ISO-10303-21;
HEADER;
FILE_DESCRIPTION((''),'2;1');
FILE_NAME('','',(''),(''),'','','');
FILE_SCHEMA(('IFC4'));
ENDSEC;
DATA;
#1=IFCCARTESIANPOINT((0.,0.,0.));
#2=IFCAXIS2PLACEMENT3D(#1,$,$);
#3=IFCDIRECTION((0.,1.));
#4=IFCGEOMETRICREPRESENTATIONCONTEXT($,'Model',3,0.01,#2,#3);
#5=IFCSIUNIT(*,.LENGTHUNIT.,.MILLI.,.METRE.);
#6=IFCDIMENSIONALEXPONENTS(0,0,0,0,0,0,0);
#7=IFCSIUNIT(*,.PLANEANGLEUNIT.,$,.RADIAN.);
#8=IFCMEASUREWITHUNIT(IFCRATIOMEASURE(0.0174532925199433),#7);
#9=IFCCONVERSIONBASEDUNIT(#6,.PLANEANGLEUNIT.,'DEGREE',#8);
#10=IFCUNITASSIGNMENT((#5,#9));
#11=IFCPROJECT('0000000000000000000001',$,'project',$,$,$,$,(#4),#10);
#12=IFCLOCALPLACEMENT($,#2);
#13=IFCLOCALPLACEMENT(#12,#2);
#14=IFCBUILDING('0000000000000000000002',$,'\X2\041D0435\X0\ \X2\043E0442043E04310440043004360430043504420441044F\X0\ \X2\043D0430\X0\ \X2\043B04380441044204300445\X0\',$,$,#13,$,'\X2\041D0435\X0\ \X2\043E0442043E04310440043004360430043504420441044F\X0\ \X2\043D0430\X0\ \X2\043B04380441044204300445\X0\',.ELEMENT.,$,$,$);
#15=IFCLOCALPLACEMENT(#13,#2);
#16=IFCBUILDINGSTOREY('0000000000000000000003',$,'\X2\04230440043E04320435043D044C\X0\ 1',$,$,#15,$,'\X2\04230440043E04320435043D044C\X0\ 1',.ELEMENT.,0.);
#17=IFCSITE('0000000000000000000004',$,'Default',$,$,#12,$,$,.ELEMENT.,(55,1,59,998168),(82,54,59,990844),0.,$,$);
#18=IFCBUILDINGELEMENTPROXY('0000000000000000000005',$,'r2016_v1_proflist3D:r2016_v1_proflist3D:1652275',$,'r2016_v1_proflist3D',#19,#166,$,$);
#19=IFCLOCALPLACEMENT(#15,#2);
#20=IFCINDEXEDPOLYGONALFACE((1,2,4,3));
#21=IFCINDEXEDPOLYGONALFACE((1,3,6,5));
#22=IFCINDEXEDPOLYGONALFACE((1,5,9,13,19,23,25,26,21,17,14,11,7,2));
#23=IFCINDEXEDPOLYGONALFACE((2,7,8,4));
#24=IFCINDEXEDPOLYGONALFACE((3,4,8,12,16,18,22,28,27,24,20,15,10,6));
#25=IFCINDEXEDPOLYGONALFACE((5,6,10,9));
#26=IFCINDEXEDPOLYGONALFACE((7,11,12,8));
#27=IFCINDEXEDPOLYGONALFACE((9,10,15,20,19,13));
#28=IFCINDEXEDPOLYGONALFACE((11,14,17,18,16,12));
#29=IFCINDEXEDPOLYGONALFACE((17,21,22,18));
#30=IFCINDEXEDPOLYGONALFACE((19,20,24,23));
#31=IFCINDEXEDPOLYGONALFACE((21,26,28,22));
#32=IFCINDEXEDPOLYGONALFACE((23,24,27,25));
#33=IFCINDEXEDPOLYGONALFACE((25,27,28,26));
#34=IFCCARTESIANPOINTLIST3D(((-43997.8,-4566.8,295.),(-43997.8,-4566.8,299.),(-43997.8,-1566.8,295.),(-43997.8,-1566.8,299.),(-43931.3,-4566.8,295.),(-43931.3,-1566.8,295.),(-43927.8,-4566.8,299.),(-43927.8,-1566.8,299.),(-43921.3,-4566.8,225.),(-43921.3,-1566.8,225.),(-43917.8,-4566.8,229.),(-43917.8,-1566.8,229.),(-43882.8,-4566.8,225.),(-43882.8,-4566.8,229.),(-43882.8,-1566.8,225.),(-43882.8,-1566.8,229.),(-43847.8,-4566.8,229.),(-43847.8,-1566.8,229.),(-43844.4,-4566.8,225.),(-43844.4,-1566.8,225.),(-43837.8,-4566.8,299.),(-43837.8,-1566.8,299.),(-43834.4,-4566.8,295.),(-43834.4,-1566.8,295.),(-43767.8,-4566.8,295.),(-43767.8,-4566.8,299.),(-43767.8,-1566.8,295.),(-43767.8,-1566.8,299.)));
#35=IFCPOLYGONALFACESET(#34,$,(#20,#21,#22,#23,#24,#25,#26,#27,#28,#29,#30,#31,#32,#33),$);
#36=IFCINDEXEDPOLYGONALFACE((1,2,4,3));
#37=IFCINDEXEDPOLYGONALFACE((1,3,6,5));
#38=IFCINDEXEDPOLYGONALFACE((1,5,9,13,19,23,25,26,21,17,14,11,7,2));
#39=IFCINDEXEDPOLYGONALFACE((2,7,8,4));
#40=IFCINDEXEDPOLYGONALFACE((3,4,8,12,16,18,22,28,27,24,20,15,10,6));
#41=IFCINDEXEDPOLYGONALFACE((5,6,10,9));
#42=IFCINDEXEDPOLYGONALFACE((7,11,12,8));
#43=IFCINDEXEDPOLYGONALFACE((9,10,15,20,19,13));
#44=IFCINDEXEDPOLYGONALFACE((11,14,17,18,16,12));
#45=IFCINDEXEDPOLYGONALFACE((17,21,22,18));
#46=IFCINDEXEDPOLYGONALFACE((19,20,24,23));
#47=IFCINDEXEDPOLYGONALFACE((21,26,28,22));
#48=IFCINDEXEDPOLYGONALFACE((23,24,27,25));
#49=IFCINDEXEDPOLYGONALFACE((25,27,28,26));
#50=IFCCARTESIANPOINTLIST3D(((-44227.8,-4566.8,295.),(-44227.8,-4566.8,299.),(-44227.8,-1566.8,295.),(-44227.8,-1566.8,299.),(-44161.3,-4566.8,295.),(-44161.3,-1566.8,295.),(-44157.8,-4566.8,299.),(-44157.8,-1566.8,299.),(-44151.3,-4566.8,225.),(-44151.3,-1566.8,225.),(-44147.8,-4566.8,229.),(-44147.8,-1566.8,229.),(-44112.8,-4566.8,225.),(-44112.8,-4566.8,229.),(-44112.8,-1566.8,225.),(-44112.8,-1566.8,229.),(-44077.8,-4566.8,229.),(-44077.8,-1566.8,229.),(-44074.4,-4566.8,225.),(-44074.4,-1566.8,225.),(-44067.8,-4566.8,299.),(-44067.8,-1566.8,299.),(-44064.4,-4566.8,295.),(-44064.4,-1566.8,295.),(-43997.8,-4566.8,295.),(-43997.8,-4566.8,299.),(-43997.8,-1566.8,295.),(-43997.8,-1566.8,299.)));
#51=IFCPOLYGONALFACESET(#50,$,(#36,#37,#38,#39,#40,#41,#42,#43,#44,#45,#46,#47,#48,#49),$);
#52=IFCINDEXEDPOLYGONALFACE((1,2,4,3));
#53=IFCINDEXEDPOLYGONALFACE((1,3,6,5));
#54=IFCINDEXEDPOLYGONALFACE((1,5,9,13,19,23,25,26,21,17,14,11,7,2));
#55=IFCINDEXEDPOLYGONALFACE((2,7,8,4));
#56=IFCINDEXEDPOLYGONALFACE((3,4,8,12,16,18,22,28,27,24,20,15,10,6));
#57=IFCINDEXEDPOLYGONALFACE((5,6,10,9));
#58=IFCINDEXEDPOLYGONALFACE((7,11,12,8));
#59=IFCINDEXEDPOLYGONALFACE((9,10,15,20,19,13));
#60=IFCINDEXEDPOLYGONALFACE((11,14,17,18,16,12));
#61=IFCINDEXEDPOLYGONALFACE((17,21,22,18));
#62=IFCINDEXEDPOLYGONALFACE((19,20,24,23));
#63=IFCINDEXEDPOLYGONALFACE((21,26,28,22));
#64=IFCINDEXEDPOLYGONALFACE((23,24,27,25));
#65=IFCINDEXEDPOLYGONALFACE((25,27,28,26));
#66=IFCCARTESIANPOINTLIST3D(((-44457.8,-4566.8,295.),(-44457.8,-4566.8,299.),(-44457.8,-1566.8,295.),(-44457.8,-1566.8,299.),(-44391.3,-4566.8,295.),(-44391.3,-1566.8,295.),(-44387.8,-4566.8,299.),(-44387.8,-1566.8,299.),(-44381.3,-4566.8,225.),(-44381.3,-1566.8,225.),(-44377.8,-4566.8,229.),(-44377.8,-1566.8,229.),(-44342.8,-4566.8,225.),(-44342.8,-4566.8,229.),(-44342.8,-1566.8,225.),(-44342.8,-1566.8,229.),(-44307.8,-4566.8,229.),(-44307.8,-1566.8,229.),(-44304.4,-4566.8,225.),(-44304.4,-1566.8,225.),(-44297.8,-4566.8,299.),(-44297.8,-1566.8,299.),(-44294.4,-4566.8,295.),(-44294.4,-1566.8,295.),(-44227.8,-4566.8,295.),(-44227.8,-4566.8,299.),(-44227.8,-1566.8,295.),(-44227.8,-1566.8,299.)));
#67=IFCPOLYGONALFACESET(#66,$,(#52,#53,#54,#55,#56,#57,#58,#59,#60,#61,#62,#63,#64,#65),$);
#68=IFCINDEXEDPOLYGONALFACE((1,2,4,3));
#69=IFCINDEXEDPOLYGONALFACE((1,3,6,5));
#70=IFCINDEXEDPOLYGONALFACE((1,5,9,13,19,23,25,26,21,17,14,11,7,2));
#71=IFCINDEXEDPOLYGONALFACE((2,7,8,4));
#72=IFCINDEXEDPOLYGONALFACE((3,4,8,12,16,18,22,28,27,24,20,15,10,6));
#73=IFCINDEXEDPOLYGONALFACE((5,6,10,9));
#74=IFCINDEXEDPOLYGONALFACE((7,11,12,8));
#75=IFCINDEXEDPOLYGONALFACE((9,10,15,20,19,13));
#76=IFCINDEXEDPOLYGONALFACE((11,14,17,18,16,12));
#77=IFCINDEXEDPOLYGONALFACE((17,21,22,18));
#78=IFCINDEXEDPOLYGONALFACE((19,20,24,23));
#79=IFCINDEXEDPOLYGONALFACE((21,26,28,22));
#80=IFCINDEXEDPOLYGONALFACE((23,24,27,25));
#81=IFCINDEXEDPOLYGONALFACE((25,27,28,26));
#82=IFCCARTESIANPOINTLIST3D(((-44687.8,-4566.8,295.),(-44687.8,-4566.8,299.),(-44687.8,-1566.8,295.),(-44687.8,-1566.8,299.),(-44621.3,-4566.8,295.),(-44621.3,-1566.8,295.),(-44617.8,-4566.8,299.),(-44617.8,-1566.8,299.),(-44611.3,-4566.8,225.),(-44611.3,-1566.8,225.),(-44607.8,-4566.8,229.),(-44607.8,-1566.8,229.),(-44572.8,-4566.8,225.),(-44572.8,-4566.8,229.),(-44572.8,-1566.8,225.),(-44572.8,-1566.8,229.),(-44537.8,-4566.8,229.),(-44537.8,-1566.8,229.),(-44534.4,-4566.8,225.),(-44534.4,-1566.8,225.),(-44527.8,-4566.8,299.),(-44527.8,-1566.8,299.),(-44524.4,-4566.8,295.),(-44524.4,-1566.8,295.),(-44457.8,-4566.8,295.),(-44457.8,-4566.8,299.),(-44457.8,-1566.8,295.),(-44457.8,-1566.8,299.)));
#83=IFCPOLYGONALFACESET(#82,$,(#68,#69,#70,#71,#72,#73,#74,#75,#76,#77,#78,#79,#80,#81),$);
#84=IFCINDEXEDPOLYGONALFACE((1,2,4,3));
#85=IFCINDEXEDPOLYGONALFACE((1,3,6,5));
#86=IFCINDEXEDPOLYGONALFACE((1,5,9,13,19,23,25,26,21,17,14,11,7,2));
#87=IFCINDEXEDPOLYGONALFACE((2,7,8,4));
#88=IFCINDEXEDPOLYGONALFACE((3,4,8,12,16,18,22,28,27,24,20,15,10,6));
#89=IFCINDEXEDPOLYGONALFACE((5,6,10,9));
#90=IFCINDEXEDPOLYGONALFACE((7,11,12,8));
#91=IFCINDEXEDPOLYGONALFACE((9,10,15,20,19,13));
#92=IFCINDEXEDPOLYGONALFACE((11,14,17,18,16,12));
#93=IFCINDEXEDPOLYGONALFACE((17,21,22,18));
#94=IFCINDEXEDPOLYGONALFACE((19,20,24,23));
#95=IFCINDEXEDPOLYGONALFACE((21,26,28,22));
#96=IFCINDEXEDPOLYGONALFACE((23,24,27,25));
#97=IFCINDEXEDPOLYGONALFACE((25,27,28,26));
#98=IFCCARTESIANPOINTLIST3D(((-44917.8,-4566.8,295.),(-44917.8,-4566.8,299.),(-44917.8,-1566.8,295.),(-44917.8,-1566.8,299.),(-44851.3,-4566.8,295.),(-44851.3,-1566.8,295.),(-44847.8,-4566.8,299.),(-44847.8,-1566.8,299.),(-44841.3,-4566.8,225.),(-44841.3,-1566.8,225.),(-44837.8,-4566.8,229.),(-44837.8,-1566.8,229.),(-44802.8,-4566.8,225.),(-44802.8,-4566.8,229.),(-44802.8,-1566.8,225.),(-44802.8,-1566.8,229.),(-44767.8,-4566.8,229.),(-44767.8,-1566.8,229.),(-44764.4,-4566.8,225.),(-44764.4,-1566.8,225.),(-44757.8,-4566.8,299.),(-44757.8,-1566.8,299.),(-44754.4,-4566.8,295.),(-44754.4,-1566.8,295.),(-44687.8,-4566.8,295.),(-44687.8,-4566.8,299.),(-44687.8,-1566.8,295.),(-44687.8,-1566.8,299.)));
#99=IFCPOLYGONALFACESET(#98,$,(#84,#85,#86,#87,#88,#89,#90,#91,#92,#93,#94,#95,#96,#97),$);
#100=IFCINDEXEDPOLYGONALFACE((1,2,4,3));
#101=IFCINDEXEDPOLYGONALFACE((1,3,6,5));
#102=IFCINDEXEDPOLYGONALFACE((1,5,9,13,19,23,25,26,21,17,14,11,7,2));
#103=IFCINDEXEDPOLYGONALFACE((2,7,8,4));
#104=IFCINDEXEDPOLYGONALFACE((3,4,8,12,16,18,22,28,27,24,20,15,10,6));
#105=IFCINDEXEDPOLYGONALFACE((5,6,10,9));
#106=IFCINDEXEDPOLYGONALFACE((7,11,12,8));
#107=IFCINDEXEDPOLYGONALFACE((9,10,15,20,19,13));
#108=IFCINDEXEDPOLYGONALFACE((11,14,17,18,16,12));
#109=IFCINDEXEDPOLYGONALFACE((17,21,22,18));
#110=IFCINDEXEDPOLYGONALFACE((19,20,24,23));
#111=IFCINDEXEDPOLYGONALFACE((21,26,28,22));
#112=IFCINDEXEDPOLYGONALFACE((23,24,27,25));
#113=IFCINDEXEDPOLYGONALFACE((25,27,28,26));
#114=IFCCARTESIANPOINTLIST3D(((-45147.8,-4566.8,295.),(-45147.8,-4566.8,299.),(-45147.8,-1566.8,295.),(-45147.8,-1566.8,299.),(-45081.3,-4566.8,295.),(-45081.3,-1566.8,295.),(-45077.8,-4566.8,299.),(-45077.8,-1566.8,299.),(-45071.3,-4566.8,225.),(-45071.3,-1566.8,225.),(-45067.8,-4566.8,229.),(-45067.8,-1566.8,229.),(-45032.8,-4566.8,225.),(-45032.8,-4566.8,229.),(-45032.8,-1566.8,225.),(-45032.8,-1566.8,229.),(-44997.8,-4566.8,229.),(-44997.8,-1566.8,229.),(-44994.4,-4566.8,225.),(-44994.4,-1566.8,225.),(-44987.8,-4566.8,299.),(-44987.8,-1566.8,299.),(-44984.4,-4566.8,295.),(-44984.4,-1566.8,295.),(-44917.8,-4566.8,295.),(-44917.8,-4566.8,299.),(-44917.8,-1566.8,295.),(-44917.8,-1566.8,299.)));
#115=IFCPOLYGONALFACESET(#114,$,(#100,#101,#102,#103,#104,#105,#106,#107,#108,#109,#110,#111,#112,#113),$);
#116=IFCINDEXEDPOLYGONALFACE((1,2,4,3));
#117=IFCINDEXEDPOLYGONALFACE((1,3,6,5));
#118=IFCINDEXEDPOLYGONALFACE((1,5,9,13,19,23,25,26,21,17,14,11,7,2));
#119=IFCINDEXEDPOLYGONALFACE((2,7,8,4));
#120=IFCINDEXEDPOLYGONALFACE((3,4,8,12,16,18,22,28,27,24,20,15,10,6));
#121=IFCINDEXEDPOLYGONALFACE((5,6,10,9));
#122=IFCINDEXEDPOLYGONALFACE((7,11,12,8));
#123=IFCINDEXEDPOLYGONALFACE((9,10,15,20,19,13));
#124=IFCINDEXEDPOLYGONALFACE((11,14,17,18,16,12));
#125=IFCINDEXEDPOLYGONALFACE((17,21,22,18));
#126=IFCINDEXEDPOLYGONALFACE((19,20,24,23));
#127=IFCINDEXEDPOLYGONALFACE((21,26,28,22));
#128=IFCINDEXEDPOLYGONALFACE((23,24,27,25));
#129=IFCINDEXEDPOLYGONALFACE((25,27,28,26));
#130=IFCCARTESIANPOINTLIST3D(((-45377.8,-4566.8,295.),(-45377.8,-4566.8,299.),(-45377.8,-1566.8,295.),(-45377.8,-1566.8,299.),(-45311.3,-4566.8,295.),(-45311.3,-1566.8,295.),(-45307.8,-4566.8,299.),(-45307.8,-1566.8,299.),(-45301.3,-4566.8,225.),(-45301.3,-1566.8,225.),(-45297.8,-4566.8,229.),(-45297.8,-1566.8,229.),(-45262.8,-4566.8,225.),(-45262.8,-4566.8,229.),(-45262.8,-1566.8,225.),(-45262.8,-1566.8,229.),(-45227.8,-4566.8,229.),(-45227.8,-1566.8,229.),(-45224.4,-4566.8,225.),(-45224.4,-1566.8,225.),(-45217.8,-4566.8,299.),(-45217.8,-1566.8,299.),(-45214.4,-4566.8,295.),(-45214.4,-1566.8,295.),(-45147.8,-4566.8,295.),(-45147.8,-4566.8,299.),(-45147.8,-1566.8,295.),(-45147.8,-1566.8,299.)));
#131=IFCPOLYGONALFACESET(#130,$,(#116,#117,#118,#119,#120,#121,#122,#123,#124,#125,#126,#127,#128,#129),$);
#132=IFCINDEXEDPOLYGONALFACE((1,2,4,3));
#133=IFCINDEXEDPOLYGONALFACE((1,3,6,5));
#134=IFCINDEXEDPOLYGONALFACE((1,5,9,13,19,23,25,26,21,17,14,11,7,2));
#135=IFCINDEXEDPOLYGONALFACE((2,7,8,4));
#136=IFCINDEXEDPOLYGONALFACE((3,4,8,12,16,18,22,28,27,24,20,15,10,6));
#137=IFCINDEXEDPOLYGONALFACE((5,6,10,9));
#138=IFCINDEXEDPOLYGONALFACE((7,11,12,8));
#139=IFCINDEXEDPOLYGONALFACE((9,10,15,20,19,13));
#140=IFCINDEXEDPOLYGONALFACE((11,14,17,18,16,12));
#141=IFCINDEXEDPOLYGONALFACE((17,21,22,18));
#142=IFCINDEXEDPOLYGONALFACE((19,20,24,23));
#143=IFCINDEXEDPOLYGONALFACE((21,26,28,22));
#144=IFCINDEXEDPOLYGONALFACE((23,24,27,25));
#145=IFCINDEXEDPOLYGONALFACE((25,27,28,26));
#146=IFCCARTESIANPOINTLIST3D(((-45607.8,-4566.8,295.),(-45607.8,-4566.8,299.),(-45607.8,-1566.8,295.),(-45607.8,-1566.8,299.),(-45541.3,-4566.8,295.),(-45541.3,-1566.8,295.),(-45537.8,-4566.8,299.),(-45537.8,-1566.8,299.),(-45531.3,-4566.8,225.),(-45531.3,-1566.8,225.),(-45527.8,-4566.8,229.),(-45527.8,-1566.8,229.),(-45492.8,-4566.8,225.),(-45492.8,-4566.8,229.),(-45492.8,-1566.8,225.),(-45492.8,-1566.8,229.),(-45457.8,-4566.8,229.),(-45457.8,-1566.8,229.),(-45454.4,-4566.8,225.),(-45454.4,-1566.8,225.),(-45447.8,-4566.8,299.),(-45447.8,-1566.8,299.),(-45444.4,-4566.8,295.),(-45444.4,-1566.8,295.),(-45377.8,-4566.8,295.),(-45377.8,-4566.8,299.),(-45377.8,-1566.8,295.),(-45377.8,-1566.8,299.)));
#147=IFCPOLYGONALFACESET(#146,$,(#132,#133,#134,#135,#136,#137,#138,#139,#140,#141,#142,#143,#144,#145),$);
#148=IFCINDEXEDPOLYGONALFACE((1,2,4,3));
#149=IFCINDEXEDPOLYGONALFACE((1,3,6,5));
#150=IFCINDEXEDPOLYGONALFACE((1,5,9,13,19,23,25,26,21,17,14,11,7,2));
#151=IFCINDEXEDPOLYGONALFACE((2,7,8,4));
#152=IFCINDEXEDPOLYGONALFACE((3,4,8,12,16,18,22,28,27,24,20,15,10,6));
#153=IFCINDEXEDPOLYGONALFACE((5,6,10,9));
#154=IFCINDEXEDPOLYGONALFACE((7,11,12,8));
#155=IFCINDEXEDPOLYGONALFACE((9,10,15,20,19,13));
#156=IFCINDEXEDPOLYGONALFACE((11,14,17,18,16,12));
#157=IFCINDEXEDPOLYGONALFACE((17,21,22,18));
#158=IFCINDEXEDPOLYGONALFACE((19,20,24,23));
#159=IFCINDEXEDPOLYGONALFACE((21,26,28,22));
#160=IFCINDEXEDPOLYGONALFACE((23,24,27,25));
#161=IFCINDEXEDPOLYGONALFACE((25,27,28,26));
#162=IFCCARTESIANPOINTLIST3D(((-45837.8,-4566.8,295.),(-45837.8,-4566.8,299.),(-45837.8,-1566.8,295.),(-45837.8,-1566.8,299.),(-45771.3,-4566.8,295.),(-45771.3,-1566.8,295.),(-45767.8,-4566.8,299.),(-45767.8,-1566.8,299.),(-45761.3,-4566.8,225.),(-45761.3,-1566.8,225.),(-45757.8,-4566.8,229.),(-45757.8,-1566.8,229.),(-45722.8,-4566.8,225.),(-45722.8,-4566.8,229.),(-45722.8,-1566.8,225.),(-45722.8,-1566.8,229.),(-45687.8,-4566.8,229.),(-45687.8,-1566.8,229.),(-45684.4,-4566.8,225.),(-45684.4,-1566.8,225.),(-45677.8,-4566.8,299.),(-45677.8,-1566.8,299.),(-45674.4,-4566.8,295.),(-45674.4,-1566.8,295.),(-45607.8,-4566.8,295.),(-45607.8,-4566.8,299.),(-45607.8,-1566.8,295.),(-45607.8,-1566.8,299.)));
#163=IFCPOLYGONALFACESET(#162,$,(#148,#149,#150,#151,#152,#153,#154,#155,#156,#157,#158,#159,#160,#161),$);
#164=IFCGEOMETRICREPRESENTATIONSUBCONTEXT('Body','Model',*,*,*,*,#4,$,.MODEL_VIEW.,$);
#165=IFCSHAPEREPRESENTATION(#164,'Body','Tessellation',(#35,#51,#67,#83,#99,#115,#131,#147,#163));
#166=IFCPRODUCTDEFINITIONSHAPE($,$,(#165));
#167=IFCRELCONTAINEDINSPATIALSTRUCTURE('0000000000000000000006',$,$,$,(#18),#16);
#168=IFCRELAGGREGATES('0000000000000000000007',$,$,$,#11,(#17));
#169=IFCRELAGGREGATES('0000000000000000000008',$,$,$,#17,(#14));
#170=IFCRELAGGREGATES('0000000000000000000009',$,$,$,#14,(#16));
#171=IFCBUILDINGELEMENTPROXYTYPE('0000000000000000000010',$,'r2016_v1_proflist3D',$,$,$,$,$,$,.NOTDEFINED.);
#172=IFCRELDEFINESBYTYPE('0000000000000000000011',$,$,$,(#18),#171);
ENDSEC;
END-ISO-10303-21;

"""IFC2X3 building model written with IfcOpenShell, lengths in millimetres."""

from ifc_helpers import new_model, entity, si_unit, converted_unit, direction, frame, origin, place, context, subcontext, project, spatial, polyline, outline, extrude, source, transform, mapped, type_object, type_shapes, element, save


model = new_model("IFC2X3")

# Units and contexts
model_context = context("Model", 3, precision=0.01, world=origin(), true_north=direction((0.0, 1.0)))
body_context = subcontext(model_context, "Body", "Model", "MODEL_VIEW")
ifc_project = project(units=[si_unit("LENGTHUNIT", "METRE", prefix="MILLI"), converted_unit("PLANEANGLEUNIT", "DEGREE", entity("IfcRatioMeasure", 0.0174532925199433), si_unit("PLANEANGLEUNIT", "RADIAN"), dimensions=[0, 0, 0, 0, 0, 0, 0])], contexts=[model_context])

# Site, building, storey
site_placement = place(None, origin())
site = spatial("IfcSite", under=ifc_project, at=site_placement, Name="Default", CompositionType="ELEMENT", RefLatitude=(55, 1, 59, 998168), RefLongitude=(82, 54, 59, 990844), RefElevation=0.0)
building_placement = place(site_placement, origin())
building = spatial("IfcBuilding", under=site, at=building_placement, Name="Не отображается на листах", LongName="Не отображается на листах", CompositionType="ELEMENT")
storey_placement = place(building_placement, frame((0.0, 0.0, 0.0)))
storey = spatial("IfcBuildingStorey", under=building, at=storey_placement, Name="Уровень 1", LongName="Уровень 1", CompositionType="ELEMENT", Elevation=0.0)

# Building element proxy
building_element_proxy_type = type_object("IfcBuildingElementProxyType", Name="r2016_v1_proflist3D", PredefinedType="NOTDEFINED")
shared_shape = source(origin(), body_context, "Body", "SweptSolid", [
    extrude(outline(polyline([(-38.0, -40.0), (-47.9, -109.3), (-44.0, -109.9), (-34.6, -44.0), (36.1, -44.0), (41.6, -5.9), (47.0, 32.1), (-20.9, 51.9), (-11.5, 117.8), (-15.4, 118.4), (-25.3, 49.1), (42.6, 29.3), (37.6, -5.4), (32.7, -40.0), (-38.0, -40.0)])), frame((1955.0, -3000.0, -32.0), z_axis=(0.0, -1.0, 0.0), x_axis=(0.141421, 0.0, -0.989949)), (0.0, 0.0, -1.0), 3000.0),
    extrude(outline(polyline([(-38.0, -40.0), (-47.9, -109.3), (-44.0, -109.9), (-34.6, -44.0), (36.1, -44.0), (41.6, -5.9), (47.0, 32.1), (-20.9, 51.9), (-11.5, 117.8), (-15.4, 118.4), (-25.3, 49.1), (42.6, 29.3), (37.6, -5.4), (32.7, -40.0), (-38.0, -40.0)])), frame((1725.0, -3000.0, -32.0), z_axis=(0.0, -1.0, 0.0), x_axis=(0.141421, 0.0, -0.989949)), (0.0, 0.0, -1.0), 3000.0),
    extrude(outline(polyline([(-38.0, -40.0), (-47.9, -109.3), (-44.0, -109.9), (-34.6, -44.0), (36.1, -44.0), (41.6, -5.9), (47.0, 32.1), (-20.9, 51.9), (-11.5, 117.8), (-15.4, 118.4), (-25.3, 49.1), (42.6, 29.3), (37.6, -5.4), (32.7, -40.0), (-38.0, -40.0)])), frame((1495.0, -3000.0, -32.0), z_axis=(0.0, -1.0, 0.0), x_axis=(0.141421, 0.0, -0.989949)), (0.0, 0.0, -1.0), 3000.0),
    extrude(outline(polyline([(-38.0, -40.0), (-47.9, -109.3), (-44.0, -109.9), (-34.6, -44.0), (36.1, -44.0), (41.6, -5.9), (47.0, 32.1), (-20.9, 51.9), (-11.5, 117.8), (-15.4, 118.4), (-25.3, 49.1), (42.6, 29.3), (37.6, -5.4), (32.7, -40.0), (-38.0, -40.0)])), frame((1265.0, -3000.0, -32.0), z_axis=(0.0, -1.0, 0.0), x_axis=(0.141421, 0.0, -0.989949)), (0.0, 0.0, -1.0), 3000.0),
    extrude(outline(polyline([(-38.0, -40.0), (-47.9, -109.3), (-44.0, -109.9), (-34.6, -44.0), (36.1, -44.0), (41.6, -5.9), (47.0, 32.1), (-20.9, 51.9), (-11.5, 117.8), (-15.4, 118.4), (-25.3, 49.1), (42.6, 29.3), (37.6, -5.4), (32.7, -40.0), (-38.0, -40.0)])), frame((1035.0, -3000.0, -32.0), z_axis=(0.0, -1.0, 0.0), x_axis=(0.141421, 0.0, -0.989949)), (0.0, 0.0, -1.0), 3000.0),
    extrude(outline(polyline([(-38.0, -40.0), (-47.9, -109.3), (-44.0, -109.9), (-34.6, -44.0), (36.1, -44.0), (41.6, -5.9), (47.0, 32.1), (-20.9, 51.9), (-11.5, 117.8), (-15.4, 118.4), (-25.3, 49.1), (42.6, 29.3), (37.6, -5.4), (32.7, -40.0), (-38.0, -40.0)])), frame((805.0, -3000.0, -32.0), z_axis=(0.0, -1.0, 0.0), x_axis=(0.141421, 0.0, -0.989949)), (0.0, 0.0, -1.0), 3000.0),
    extrude(outline(polyline([(-38.0, -40.0), (-47.9, -109.3), (-44.0, -109.9), (-34.6, -44.0), (36.1, -44.0), (41.6, -5.9), (47.0, 32.1), (-20.9, 51.9), (-11.5, 117.8), (-15.4, 118.4), (-25.3, 49.1), (42.6, 29.3), (37.6, -5.4), (32.7, -40.0), (-38.0, -40.0)])), frame((575.0, -3000.0, -32.0), z_axis=(0.0, -1.0, 0.0), x_axis=(0.141421, 0.0, -0.989949)), (0.0, 0.0, -1.0), 3000.0),
    extrude(outline(polyline([(-38.0, -40.0), (-47.9, -109.3), (-44.0, -109.9), (-34.6, -44.0), (36.1, -44.0), (41.6, -5.9), (47.0, 32.1), (-20.9, 51.9), (-11.5, 117.8), (-15.4, 118.4), (-25.3, 49.1), (42.6, 29.3), (37.6, -5.4), (32.7, -40.0), (-38.0, -40.0)])), frame((345.0, -3000.0, -32.0), z_axis=(0.0, -1.0, 0.0), x_axis=(0.141421, 0.0, -0.989949)), (0.0, 0.0, -1.0), 3000.0),
    extrude(outline(polyline([(-38.0, -40.0), (-47.9, -109.3), (-44.0, -109.9), (-34.6, -44.0), (36.1, -44.0), (41.6, -5.9), (47.0, 32.1), (-20.9, 51.9), (-11.5, 117.8), (-15.4, 118.4), (-25.3, 49.1), (42.6, 29.3), (37.6, -5.4), (32.7, -40.0), (-38.0, -40.0)])), frame((115.0, -3000.0, -32.0), z_axis=(0.0, -1.0, 0.0), x_axis=(0.141421, 0.0, -0.989949)), (0.0, 0.0, -1.0), 3000.0),
])
type_shapes(building_element_proxy_type, [shared_shape])
proxy_1_placement = place(storey_placement, frame((-45837.8, -1566.8, 299.0)))
element("IfcBuildingElementProxy", 1, at=proxy_1_placement, inside=storey, type_object=building_element_proxy_type, Name="r2016_v1_proflist3D:r2016_v1_proflist3D:1652275", ObjectType="r2016_v1_proflist3D", context=body_context, shape_type="MappedRepresentation", body=[
    mapped(shared_shape, transform((0.0, 0.0, 0.0), scale=1.0)),
])

save(model, "model.ifc")
